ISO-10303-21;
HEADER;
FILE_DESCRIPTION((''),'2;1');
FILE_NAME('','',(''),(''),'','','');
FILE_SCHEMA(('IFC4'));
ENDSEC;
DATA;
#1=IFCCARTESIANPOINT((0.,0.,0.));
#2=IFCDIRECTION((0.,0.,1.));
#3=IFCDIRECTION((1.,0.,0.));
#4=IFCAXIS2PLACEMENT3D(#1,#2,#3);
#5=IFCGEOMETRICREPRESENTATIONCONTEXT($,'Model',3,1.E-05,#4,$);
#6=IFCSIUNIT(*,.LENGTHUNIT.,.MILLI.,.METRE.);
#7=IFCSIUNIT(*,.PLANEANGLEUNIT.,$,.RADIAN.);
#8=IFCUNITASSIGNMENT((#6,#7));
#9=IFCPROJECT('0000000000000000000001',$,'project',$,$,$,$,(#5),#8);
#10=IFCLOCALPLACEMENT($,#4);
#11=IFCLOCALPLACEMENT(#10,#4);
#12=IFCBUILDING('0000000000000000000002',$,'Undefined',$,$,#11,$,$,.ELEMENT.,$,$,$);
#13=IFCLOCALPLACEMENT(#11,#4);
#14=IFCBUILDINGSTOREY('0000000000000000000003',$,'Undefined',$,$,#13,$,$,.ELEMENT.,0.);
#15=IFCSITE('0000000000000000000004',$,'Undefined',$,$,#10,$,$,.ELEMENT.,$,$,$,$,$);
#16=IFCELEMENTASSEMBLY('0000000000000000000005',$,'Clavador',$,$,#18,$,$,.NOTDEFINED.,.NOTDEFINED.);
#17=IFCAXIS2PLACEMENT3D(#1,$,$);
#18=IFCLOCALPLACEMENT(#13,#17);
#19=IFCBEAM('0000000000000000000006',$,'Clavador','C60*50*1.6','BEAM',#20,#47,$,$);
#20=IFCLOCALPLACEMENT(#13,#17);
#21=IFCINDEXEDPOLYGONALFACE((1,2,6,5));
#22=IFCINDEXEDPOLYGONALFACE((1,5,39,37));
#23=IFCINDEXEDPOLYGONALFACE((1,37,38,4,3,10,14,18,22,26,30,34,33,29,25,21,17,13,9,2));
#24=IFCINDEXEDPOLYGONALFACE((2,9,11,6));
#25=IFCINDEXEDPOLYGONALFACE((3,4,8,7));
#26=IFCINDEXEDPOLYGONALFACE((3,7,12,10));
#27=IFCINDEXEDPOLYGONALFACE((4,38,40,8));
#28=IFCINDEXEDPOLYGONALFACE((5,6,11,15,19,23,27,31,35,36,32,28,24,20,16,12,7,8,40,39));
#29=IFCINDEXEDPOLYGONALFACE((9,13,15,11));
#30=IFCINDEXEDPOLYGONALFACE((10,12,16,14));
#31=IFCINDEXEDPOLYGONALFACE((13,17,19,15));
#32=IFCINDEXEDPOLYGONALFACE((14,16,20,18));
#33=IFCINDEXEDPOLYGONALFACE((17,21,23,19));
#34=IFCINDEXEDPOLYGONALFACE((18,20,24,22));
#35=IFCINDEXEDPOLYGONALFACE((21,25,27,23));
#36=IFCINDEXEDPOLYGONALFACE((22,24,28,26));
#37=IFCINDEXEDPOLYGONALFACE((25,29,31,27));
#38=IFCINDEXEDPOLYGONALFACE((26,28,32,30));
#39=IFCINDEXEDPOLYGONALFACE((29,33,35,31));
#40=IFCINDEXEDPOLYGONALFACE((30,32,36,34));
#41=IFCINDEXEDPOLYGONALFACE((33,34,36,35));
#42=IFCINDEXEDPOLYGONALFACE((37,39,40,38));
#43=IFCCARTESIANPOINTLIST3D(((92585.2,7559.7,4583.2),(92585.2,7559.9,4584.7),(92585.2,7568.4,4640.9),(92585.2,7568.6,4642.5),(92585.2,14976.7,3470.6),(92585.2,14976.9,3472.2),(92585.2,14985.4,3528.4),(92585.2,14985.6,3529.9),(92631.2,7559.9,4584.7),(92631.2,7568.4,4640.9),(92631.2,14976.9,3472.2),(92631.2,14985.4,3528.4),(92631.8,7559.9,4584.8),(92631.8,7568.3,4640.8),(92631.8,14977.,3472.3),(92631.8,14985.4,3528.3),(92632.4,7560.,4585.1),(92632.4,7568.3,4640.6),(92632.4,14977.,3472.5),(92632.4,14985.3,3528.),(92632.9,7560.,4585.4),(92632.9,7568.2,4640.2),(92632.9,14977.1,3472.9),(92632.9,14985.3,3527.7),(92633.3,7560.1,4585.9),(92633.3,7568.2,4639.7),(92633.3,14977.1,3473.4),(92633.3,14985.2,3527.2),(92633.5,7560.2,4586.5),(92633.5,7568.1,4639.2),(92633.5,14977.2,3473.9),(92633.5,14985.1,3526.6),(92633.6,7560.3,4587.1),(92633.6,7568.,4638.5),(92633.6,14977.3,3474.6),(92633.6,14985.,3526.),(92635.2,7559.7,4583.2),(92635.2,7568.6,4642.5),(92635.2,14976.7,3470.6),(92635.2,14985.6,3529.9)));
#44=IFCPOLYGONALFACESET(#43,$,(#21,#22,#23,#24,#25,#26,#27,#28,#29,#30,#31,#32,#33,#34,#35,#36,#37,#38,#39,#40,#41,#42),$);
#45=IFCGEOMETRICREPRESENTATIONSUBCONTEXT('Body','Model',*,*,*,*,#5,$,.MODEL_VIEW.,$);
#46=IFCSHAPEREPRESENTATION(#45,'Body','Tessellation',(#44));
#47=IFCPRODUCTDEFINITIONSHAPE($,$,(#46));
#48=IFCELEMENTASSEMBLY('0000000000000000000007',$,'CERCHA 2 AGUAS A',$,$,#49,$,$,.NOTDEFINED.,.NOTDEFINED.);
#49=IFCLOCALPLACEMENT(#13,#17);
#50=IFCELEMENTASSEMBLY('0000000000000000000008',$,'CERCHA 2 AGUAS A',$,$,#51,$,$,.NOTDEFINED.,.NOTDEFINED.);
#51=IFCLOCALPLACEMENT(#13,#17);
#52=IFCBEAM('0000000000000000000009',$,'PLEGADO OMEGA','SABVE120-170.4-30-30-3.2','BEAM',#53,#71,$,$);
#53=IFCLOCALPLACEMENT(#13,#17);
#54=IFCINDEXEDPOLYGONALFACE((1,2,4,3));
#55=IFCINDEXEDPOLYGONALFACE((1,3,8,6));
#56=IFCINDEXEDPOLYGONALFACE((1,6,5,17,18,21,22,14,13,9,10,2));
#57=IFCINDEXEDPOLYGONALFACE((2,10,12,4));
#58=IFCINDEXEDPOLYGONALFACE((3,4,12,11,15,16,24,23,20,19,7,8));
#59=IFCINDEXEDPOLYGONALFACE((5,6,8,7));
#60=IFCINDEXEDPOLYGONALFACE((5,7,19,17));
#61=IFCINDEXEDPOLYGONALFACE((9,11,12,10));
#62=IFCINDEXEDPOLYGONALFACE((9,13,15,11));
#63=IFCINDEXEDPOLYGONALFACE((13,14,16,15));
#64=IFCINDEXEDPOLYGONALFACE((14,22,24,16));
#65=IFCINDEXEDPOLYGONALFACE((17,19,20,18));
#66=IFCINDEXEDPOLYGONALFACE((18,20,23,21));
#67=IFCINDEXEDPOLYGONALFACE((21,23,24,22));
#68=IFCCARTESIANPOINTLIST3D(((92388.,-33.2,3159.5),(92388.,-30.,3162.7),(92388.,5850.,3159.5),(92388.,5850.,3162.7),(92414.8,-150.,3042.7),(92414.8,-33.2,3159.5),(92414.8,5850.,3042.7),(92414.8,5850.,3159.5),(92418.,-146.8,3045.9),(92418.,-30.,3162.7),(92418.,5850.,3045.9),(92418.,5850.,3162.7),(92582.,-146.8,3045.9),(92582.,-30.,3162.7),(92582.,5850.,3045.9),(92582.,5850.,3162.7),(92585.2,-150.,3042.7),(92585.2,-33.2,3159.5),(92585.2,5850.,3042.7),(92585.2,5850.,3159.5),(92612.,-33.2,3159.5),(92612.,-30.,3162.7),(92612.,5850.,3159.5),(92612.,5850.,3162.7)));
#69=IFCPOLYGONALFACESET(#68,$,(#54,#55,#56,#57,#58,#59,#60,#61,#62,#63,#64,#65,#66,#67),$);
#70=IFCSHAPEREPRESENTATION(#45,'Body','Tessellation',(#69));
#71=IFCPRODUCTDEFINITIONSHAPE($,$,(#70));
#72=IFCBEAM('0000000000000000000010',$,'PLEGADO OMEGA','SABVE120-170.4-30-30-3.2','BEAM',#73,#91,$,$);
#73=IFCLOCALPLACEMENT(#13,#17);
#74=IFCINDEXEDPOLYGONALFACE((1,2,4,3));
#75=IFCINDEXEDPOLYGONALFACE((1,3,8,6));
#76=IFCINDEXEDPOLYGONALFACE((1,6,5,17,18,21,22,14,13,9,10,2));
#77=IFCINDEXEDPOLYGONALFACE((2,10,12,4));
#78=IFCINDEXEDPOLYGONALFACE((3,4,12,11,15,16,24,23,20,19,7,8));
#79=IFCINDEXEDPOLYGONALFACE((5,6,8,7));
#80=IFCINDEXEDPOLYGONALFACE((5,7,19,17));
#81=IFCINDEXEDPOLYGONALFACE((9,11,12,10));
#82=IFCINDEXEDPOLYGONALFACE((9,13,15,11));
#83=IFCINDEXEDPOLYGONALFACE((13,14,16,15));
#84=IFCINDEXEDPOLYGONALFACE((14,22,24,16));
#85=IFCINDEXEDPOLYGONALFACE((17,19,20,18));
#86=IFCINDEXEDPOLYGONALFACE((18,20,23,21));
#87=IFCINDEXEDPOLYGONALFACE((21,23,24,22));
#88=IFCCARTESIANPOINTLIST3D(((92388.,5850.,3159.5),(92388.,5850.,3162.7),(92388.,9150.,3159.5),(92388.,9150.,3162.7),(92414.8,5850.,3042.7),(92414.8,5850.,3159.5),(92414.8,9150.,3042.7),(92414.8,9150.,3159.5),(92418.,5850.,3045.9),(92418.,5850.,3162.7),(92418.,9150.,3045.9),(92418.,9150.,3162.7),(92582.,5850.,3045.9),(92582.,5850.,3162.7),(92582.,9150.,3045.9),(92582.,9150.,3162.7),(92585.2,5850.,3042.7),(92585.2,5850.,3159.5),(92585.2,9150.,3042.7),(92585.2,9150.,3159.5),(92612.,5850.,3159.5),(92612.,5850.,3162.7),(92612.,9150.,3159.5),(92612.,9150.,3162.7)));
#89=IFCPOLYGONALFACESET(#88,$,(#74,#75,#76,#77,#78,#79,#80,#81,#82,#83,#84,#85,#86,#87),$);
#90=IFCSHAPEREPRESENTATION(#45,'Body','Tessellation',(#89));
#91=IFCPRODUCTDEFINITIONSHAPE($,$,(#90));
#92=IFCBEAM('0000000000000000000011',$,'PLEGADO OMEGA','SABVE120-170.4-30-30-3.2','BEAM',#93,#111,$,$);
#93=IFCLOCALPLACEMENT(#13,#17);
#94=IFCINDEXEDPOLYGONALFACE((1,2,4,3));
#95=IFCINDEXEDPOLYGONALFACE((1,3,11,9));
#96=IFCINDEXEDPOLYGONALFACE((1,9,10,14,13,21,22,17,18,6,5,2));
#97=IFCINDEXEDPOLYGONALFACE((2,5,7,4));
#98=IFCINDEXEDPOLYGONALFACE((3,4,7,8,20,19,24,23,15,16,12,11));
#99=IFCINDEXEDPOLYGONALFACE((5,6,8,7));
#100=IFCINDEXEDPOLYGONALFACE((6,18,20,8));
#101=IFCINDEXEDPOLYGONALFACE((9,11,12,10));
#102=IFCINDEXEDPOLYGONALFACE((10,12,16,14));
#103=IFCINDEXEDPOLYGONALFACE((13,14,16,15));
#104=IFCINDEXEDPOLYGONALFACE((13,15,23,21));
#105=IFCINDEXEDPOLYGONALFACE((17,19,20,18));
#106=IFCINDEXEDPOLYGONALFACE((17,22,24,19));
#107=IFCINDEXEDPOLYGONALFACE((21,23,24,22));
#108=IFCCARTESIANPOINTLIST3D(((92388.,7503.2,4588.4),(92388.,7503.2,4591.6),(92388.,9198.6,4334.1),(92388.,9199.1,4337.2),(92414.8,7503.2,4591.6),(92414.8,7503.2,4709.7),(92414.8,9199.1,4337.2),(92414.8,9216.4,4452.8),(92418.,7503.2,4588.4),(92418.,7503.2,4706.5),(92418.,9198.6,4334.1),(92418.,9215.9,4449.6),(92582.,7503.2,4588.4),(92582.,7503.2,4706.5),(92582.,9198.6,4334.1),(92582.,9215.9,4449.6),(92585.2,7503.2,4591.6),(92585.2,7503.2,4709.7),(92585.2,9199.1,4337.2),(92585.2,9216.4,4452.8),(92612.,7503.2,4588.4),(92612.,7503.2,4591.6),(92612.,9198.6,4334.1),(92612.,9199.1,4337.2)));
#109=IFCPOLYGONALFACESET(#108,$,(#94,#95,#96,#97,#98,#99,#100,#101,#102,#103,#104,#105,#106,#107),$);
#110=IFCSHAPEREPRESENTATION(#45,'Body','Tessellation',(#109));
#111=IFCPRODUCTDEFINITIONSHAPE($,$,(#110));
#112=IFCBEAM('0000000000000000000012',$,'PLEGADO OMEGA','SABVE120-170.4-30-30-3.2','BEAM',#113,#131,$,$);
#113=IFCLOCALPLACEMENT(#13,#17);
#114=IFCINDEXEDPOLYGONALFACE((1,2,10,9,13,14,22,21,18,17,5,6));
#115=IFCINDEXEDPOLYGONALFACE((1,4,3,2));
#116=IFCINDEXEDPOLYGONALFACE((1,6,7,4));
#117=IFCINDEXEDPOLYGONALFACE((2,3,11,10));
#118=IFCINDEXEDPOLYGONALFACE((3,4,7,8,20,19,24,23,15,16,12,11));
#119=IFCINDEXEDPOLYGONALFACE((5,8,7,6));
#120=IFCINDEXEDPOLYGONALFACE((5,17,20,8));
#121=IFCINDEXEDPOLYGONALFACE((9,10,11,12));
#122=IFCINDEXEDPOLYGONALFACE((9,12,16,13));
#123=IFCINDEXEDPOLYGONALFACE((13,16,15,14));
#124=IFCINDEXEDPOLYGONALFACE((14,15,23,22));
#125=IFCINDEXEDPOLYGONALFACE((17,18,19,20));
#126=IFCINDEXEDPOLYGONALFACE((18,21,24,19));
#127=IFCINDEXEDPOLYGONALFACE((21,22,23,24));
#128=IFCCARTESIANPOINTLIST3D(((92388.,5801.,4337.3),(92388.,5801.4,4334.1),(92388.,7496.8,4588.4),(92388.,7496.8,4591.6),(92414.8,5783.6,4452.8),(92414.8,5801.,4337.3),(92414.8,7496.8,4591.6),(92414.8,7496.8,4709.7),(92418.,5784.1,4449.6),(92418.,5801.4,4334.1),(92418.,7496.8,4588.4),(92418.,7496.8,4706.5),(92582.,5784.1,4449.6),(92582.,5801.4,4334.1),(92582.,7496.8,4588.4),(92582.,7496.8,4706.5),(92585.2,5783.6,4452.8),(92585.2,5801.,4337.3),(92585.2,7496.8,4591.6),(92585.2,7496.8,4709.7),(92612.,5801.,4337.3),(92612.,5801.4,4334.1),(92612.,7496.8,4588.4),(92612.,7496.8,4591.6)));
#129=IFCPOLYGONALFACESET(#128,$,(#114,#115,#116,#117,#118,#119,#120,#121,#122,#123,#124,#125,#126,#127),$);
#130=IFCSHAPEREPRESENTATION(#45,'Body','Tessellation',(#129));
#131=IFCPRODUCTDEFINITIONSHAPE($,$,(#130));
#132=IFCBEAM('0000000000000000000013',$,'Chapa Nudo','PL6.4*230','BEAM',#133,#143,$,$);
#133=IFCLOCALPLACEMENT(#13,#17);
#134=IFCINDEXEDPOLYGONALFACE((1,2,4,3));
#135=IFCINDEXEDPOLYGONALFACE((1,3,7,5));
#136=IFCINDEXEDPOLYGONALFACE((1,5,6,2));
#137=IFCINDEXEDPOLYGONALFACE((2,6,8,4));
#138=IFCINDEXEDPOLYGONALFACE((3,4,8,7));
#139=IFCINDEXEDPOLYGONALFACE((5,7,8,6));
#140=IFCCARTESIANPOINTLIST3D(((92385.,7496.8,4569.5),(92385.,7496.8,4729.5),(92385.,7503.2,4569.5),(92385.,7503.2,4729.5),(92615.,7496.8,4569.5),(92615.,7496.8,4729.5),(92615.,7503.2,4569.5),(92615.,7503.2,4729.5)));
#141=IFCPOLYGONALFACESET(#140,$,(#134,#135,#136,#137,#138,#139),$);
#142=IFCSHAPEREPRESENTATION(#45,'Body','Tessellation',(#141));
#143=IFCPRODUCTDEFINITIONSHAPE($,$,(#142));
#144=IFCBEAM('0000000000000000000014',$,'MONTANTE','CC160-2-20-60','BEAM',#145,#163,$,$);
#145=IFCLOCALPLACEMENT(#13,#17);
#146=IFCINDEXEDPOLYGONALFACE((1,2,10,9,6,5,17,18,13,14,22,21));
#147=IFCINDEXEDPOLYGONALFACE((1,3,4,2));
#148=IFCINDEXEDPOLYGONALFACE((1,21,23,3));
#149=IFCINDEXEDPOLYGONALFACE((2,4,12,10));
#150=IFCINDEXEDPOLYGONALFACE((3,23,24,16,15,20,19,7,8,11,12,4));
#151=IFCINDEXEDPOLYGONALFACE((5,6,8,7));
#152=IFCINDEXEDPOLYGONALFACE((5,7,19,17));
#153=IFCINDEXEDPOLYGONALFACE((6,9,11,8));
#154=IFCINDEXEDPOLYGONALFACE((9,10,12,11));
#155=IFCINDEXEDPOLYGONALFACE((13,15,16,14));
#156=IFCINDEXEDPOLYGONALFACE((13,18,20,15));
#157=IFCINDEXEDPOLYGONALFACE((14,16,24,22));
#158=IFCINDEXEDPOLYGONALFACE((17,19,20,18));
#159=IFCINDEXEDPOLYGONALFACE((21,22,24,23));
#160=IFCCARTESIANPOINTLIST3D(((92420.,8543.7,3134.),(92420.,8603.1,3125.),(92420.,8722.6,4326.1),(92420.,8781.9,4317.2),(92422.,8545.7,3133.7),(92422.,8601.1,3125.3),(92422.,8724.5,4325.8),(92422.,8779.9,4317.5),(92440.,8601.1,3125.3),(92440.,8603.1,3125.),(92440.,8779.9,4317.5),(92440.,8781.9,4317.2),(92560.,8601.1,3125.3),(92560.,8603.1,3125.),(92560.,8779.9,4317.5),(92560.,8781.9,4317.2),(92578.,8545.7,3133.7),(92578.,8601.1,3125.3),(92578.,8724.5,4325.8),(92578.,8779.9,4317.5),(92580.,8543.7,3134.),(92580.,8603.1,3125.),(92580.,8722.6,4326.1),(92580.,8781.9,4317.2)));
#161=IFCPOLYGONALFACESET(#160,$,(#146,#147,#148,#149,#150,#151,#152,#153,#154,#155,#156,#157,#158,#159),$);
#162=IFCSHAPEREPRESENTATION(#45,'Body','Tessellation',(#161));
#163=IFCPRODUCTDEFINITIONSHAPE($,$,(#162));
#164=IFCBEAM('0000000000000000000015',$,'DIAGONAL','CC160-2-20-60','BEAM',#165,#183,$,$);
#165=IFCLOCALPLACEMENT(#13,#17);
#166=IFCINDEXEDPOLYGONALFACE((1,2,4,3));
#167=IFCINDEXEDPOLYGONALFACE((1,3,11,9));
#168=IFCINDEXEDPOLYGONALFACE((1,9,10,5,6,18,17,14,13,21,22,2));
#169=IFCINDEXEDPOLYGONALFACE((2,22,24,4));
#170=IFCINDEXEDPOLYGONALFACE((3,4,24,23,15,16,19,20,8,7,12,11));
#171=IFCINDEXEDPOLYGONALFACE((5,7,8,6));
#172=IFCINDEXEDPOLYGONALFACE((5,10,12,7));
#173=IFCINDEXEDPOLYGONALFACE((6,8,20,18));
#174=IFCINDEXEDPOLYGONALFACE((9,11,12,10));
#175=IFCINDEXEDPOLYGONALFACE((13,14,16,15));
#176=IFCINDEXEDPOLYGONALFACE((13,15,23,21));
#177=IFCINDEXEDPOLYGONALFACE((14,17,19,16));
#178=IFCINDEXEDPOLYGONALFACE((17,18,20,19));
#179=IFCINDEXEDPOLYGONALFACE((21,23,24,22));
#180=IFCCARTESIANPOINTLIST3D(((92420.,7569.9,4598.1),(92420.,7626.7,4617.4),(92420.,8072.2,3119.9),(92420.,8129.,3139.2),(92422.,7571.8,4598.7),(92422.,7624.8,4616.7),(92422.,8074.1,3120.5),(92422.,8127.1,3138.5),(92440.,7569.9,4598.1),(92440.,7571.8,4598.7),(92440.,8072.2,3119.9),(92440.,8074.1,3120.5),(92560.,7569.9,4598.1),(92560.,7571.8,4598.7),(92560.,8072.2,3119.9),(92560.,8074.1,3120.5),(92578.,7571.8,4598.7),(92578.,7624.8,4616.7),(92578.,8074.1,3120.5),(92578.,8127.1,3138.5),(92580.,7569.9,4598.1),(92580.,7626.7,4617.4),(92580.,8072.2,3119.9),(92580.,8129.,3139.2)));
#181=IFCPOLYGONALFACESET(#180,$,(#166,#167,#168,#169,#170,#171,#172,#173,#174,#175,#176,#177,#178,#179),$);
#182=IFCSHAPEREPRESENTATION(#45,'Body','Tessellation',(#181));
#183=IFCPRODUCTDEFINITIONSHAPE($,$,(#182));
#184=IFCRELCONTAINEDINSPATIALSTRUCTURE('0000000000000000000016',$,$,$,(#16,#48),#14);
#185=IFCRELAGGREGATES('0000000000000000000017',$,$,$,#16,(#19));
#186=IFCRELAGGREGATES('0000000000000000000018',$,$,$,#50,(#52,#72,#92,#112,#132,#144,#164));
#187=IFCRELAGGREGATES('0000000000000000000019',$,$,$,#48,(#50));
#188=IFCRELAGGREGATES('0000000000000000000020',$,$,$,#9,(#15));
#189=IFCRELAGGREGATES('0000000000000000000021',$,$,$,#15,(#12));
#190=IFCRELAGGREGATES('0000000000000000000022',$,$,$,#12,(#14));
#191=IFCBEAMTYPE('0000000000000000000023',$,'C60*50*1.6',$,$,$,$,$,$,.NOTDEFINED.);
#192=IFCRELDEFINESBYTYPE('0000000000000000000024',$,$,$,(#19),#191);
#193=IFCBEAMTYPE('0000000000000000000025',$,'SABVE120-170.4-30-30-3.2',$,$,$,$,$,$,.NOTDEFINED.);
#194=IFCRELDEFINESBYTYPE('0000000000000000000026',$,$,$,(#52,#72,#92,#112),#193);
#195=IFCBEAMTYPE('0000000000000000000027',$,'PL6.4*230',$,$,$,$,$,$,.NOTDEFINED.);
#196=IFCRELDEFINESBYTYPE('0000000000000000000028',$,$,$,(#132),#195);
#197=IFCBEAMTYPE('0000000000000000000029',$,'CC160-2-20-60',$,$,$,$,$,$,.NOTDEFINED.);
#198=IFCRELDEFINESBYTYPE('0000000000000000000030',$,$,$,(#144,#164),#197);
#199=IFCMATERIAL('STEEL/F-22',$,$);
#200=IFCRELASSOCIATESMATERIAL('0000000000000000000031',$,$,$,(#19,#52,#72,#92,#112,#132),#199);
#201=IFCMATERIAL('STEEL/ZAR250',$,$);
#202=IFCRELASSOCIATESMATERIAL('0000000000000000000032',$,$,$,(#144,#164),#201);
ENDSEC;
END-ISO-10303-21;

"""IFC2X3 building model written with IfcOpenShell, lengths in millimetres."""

from ifc_helpers import new_model, si_unit, frame, origin_with_axes, origin_2d_with_axis, place, context, subcontext, project, spatial, polyline, rectangle, u_section, c_section, outline, extrude, clip, halfspace, material, type_object, element, aggregate, save


model = new_model("IFC2X3")

# Units and contexts
model_context = context("Model", 3, precision=1e-05, world=origin_with_axes())
body_context = subcontext(model_context, "Body", "Model", "MODEL_VIEW")
ifc_project = project(units=[si_unit("LENGTHUNIT", "METRE", prefix="MILLI"), si_unit("PLANEANGLEUNIT", "RADIAN")], contexts=[model_context])

# Site, building, storey
site_placement = place(None, origin_with_axes())
site = spatial("IfcSite", under=ifc_project, at=site_placement, Name="Undefined", CompositionType="ELEMENT")
building_placement = place(site_placement, origin_with_axes())
building = spatial("IfcBuilding", under=site, at=building_placement, Name="Undefined", CompositionType="ELEMENT")
storey_placement = place(building_placement, origin_with_axes())
storey = spatial("IfcBuildingStorey", under=building, at=storey_placement, Name="Undefined", CompositionType="ELEMENT", Elevation=0.0)

# Element assembly, beam
assembly_1_placement = place(storey_placement, origin_with_axes())
assembly_1 = element("IfcElementAssembly", 1, at=assembly_1_placement, inside=storey, Name="Clavador", AssemblyPlace="NOTDEFINED", PredefinedType="NOTDEFINED")
ifc_material_1 = material(Name="STEEL/F-22")
beam_type_1 = type_object("IfcBeamType", Name="C60*50*1.6", PredefinedType="NOTDEFINED")
beam_1_placement = place(assembly_1_placement, frame((92610.2, 7564.1, 4612.8), z_axis=(0.0, -0.14834, -0.988936), x_axis=(0.0, 0.988936, -0.14834)))
beam_1 = element("IfcBeam", 2, at=beam_1_placement, type_object=beam_type_1, material=ifc_material_1, Name="Clavador", Description="C60*50*1.6", ObjectType="BEAM", context=body_context, shape_type="SweptSolid", body=[
    extrude(u_section(Depth=60.0, FlangeWidth=50.0, WebThickness=1.6, FlangeThickness=1.6, FilletRadius=2.4, at=origin_2d_with_axis()), frame((7500.0, 0.0, 0.0), z_axis=(-1.0, 0.0, 0.0), x_axis=(0.0, -1.0, 0.0)), (0.0, 0.0, 1.0), 7500.0),
])
aggregate(assembly_1, [beam_1])

# Element assemblies, beams
assembly_2_placement = place(storey_placement, origin_with_axes())
assembly_2 = element("IfcElementAssembly", 3, at=assembly_2_placement, inside=storey, Name="CERCHA 2 AGUAS A", AssemblyPlace="NOTDEFINED", PredefinedType="NOTDEFINED")
assembly_3_placement = place(assembly_2_placement, origin_with_axes())
assembly_3 = element("IfcElementAssembly", 4, at=assembly_3_placement, Name="CERCHA 2 AGUAS A", AssemblyPlace="NOTDEFINED", PredefinedType="NOTDEFINED")
beam_type_2 = type_object("IfcBeamType", Name="SABVE120-170.4-30-30-3.2", PredefinedType="NOTDEFINED")
beam_2_placement = place(assembly_3_placement, frame((92500.0, 5850.0, 3102.7), z_axis=(0.0, 0.0, 1.0), x_axis=(0.0, -1.0, 0.0)))
beam_2 = element("IfcBeam", 5, at=beam_2_placement, type_object=beam_type_2, material=ifc_material_1, Name="PLEGADO OMEGA", Description="SABVE120-170.4-30-30-3.2", ObjectType="BEAM", context=body_context, shape_type="Clipping", body=[
    clip(extrude(outline(polyline([(82.0, 60.0), (112.0, 60.0), (112.0, 56.8), (85.2, 56.8), (85.2, -60.0), (-85.2, -60.0), (-85.2, 56.8), (-112.0, 56.8), (-112.0, 60.0), (-82.0, 60.0), (-82.0, -56.8), (82.0, -56.8), (82.0, 60.0)])), frame((6000.6, 0.0, 0.0), z_axis=(-1.0, 0.0, 0.0), x_axis=(0.0, -1.0, 0.0)), (0.0, 0.0, 1.0), 6000.6), halfspace(frame((5880.0, 0.0, 60.0), z_axis=(0.707106, 0.0, 0.707108), x_axis=(0.0, 1.0, 0.0)), False)),
])
beam_3_placement = place(assembly_3_placement, frame((92500.0, 9150.0, 3102.7), z_axis=(0.0, 0.0, 1.0), x_axis=(0.0, -1.0, 0.0)))
beam_3 = element("IfcBeam", 6, at=beam_3_placement, type_object=beam_type_2, material=ifc_material_1, Name="PLEGADO OMEGA", Description="SABVE120-170.4-30-30-3.2", ObjectType="BEAM", context=body_context, shape_type="SweptSolid", body=[
    extrude(outline(polyline([(82.0, 60.0), (112.0, 60.0), (112.0, 56.8), (85.2, 56.8), (85.2, -60.0), (-85.2, -60.0), (-85.2, 56.8), (-112.0, 56.8), (-112.0, 60.0), (-82.0, 60.0), (-82.0, -56.8), (82.0, -56.8), (82.0, 60.0)])), frame((3300.0, 0.0, 0.0), z_axis=(-1.0, 0.0, 0.0), x_axis=(0.0, -1.0, 0.0)), (0.0, 0.0, 1.0), 3300.0),
])
beam_4_placement = place(assembly_3_placement, frame((92500.0, 9207.5, 4393.4), z_axis=(0.0, -0.14834, -0.988936), x_axis=(0.0, -0.988936, 0.14834)))
beam_4 = element("IfcBeam", 7, at=beam_4_placement, type_object=beam_type_2, material=ifc_material_1, Name="PLEGADO OMEGA", Description="SABVE120-170.4-30-30-3.2", ObjectType="BEAM", context=body_context, shape_type="Clipping", body=[
    clip(extrude(outline(polyline([(82.0, 60.0), (112.0, 60.0), (112.0, 56.8), (85.2, 56.8), (85.2, -60.0), (-85.2, -60.0), (-85.2, 56.8), (-112.0, 56.8), (-112.0, 60.0), (-82.0, 60.0), (-82.0, -56.8), (82.0, -56.8), (82.0, 60.0)])), frame((1750.2, 0.0, 0.0), z_axis=(-1.0, 0.0, 0.0), x_axis=(0.0, -1.0, 0.0)), (0.0, 0.0, 1.0), 1750.2), halfspace(frame((1723.3, 0.0, 0.0), z_axis=(0.988936, 0.0, 0.14834), x_axis=(0.0, -1.0, 0.0)), False)),
])
beam_5_placement = place(assembly_3_placement, frame((92500.0, 5792.5, 4393.4), z_axis=(0.0, 0.14834, -0.988936), x_axis=(0.0, 0.988936, 0.14834)))
beam_5 = element("IfcBeam", 8, at=beam_5_placement, type_object=beam_type_2, material=ifc_material_1, Name="PLEGADO OMEGA", Description="SABVE120-170.4-30-30-3.2", ObjectType="BEAM", context=body_context, shape_type="Clipping", body=[
    clip(extrude(outline(polyline([(82.0, 60.0), (112.0, 60.0), (112.0, 56.8), (85.2, 56.8), (85.2, -60.0), (-85.2, -60.0), (-85.2, 56.8), (-112.0, 56.8), (-112.0, 60.0), (-82.0, 60.0), (-82.0, -56.8), (82.0, -56.8), (82.0, 60.0)])), frame((1750.2, 0.0, 0.0), z_axis=(-1.0, 0.0, 0.0), x_axis=(0.0, -1.0, 0.0)), (0.0, 0.0, 1.0), 1750.2), halfspace(frame((1723.3, 0.0, 0.0), z_axis=(-0.988936, 0.0, -0.14834), x_axis=(0.0, -1.0, 0.0)), True)),
])
beam_type_3 = type_object("IfcBeamType", Name="PL6.4*230", PredefinedType="NOTDEFINED")
beam_6_placement = place(assembly_3_placement, frame((92500.0, 7500.0, 4729.5), z_axis=(1.0, 0.0, 0.0), x_axis=(0.0, 0.0, -1.0)))
beam_6 = element("IfcBeam", 9, at=beam_6_placement, type_object=beam_type_3, material=ifc_material_1, Name="Chapa Nudo", Description="PL6.4*230", ObjectType="BEAM", context=body_context, shape_type="SweptSolid", body=[
    extrude(rectangle(XDim=6.4, YDim=230.0, at=origin_2d_with_axis()), frame((160.0, 0.0, 0.0), z_axis=(-1.0, 0.0, 0.0), x_axis=(0.0, -1.0, 0.0)), (0.0, 0.0, 1.0), 160.0),
])
ifc_material_2 = material(Name="STEEL/ZAR250")
beam_type_4 = type_object("IfcBeamType", Name="CC160-2-20-60", PredefinedType="NOTDEFINED")
beam_7_placement = place(assembly_3_placement, frame((92500.0, 8752.2, 4321.6), z_axis=(-1.0, 0.0, 0.0), x_axis=(0.0, -0.14834, -0.988936)))
beam_7 = element("IfcBeam", 10, at=beam_7_placement, type_object=beam_type_4, material=ifc_material_2, Name="MONTANTE", Description="CC160-2-20-60", ObjectType="BEAM", context=body_context, shape_type="SweptSolid", body=[
    extrude(c_section(Depth=160.0, Width=60.0, WallThickness=2.0, Girth=20.0, at=origin_2d_with_axis()), frame((1205.5, 0.0, 0.0), z_axis=(-1.0, 0.0, 0.0), x_axis=(0.0, -1.0, 0.0)), (0.0, 0.0, 1.0), 1205.5),
])
beam_8_placement = place(assembly_3_placement, frame((92500.0, 8100.6, 3129.5), z_axis=(-1.0, 0.0, 0.0), x_axis=(0.0, -0.321737, 0.946829)))
beam_8 = element("IfcBeam", 11, at=beam_8_placement, type_object=beam_type_4, material=ifc_material_2, Name="DIAGONAL", Description="CC160-2-20-60", ObjectType="BEAM", context=body_context, shape_type="SweptSolid", body=[
    extrude(c_section(Depth=160.0, Width=60.0, WallThickness=2.0, Girth=20.0, at=origin_2d_with_axis()), frame((1561.2, 0.0, 0.0), z_axis=(-1.0, 0.0, 0.0), x_axis=(0.0, -1.0, 0.0)), (0.0, 0.0, 1.0), 1561.2),
])

aggregate(assembly_3, [beam_2, beam_3, beam_4, beam_5, beam_6, beam_7, beam_8])
aggregate(assembly_2, [assembly_3])

save(model, "model.ifc")
